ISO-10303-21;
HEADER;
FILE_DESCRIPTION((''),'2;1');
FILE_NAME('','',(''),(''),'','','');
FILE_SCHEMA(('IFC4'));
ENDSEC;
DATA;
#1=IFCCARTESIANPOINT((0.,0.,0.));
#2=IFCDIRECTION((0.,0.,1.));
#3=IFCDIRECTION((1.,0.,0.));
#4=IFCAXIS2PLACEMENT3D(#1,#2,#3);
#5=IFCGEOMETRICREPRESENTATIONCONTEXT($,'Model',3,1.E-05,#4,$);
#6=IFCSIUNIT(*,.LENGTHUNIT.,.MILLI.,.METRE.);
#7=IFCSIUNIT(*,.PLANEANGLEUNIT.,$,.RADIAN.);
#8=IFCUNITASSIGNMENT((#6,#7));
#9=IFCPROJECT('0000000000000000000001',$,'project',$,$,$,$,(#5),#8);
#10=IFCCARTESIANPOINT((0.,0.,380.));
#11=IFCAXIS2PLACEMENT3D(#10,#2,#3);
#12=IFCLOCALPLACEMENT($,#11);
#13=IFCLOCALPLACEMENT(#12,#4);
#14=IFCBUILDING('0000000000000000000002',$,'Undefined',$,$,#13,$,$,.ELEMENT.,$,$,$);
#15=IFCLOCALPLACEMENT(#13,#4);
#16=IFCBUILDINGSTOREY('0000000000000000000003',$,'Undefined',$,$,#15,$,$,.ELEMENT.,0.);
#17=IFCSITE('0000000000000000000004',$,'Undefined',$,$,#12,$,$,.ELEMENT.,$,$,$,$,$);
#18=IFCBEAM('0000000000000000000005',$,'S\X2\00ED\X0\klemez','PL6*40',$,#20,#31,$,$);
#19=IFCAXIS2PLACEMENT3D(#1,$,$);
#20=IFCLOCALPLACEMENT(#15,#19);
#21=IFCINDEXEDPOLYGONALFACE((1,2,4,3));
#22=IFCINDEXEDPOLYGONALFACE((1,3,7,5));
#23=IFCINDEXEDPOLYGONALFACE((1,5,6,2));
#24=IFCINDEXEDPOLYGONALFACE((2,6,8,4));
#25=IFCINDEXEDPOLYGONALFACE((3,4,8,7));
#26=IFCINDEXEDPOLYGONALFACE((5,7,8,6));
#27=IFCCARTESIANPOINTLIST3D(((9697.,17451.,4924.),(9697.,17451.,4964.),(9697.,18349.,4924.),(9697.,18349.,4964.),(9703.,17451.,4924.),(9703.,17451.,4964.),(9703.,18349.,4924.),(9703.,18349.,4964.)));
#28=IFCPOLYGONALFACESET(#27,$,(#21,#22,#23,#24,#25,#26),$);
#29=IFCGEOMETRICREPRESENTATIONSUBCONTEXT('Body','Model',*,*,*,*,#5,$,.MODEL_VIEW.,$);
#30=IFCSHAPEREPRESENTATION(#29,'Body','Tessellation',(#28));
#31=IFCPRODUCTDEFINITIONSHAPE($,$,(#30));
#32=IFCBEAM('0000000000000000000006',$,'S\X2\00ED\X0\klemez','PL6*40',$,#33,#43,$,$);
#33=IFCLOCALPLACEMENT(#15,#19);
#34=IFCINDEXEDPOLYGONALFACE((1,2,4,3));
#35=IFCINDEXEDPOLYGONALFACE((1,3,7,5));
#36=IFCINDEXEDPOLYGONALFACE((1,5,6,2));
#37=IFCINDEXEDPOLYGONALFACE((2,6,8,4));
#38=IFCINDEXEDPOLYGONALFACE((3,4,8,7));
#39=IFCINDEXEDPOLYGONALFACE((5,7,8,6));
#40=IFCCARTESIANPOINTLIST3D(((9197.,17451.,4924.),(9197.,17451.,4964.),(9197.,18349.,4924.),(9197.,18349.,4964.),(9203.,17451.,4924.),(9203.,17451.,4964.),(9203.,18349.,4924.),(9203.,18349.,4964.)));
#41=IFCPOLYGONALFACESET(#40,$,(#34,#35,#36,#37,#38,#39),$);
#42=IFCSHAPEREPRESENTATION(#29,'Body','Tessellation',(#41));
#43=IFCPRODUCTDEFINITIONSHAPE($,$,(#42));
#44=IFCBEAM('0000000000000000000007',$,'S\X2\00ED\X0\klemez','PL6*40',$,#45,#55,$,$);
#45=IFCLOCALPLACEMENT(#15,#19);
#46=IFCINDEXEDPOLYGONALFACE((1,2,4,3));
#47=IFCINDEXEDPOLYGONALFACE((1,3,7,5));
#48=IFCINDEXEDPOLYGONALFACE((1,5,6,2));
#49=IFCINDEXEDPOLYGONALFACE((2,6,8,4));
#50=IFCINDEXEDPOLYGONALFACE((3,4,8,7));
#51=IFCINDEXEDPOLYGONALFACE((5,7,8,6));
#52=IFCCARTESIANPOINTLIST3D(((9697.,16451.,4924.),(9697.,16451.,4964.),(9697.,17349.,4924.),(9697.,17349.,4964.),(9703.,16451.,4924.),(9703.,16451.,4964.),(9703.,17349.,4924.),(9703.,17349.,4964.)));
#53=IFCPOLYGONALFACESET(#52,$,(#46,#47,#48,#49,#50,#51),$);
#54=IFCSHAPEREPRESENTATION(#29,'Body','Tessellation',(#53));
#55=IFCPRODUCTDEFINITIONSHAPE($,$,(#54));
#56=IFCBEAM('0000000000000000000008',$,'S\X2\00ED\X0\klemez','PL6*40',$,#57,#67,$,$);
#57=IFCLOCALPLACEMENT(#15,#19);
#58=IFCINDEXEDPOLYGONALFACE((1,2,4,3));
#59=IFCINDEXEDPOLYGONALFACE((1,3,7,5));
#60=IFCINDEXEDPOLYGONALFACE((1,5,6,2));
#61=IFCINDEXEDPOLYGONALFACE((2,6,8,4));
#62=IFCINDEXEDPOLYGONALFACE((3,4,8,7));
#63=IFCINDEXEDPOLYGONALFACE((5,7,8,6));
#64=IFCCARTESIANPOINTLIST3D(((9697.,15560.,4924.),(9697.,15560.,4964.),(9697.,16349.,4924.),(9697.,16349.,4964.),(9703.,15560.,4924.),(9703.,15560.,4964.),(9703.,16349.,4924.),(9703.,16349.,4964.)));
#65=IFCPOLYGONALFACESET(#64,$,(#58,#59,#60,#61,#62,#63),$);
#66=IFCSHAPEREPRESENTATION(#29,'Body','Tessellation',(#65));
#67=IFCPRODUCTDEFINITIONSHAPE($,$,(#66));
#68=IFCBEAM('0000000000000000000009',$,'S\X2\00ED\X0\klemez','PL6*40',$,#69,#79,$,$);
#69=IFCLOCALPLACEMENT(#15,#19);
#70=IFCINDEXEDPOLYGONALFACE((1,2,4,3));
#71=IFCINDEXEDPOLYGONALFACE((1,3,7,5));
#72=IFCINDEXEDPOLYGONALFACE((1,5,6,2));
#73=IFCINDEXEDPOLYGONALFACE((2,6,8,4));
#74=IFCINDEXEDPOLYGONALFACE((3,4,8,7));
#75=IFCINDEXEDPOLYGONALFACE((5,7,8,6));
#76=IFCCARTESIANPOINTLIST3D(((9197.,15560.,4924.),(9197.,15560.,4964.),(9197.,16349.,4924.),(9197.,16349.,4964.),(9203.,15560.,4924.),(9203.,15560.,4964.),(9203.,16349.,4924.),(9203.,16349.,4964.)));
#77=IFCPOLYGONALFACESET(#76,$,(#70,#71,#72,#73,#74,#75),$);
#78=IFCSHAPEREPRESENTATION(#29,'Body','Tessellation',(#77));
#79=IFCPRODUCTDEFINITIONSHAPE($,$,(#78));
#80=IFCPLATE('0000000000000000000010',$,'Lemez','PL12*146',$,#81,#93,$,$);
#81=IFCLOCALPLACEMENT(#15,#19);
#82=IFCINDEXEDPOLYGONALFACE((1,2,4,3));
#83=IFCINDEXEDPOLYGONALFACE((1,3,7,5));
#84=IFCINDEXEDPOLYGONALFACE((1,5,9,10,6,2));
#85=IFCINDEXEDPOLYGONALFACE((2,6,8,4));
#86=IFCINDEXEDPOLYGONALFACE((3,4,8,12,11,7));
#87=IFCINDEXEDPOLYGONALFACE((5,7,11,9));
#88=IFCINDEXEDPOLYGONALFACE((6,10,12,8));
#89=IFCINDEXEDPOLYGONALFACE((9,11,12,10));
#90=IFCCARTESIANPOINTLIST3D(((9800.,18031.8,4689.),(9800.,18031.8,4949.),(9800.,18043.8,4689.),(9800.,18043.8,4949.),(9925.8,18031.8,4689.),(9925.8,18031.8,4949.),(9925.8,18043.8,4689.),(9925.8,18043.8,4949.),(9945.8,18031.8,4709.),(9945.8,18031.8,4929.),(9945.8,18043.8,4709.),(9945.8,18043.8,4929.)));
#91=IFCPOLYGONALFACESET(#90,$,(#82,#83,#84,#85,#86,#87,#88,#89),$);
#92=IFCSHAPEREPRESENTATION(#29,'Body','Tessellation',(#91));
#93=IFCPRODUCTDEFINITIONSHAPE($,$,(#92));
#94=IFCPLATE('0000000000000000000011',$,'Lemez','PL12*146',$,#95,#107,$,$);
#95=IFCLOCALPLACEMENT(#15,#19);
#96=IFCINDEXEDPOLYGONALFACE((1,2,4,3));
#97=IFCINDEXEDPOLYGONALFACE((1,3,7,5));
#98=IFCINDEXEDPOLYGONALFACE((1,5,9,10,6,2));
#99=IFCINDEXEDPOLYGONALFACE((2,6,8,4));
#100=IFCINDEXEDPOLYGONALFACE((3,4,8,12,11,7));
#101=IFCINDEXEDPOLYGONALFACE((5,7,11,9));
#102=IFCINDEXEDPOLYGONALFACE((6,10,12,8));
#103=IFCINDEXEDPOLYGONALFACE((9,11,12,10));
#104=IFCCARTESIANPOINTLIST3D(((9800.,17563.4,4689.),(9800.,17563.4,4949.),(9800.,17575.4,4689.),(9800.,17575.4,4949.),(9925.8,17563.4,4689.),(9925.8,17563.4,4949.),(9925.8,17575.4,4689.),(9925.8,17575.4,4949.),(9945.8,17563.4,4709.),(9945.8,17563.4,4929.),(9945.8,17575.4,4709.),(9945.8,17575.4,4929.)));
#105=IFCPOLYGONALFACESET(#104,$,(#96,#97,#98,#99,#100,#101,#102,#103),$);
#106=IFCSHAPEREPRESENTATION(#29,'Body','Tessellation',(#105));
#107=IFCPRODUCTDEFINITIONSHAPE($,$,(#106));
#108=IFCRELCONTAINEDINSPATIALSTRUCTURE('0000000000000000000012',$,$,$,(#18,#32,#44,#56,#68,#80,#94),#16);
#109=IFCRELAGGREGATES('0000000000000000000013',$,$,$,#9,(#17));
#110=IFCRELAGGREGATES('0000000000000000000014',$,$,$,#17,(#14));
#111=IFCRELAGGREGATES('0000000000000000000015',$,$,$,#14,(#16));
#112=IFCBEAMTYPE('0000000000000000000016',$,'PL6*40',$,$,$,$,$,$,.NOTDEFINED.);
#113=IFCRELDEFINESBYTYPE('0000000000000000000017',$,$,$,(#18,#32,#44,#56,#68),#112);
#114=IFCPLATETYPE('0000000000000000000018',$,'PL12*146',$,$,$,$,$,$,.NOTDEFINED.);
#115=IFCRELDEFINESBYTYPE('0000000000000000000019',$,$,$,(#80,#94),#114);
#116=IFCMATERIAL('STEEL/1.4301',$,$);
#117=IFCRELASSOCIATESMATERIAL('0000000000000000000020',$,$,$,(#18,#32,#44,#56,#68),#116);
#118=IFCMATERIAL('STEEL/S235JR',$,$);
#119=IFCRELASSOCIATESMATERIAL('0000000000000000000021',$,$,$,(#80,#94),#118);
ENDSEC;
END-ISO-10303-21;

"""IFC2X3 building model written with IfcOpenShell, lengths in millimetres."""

from ifc_helpers import new_model, si_unit, frame, origin_with_axes, origin_2d_with_axis, place, context, subcontext, project, spatial, polyline, rectangle, outline, extrude, material, type_object, element, save


model = new_model("IFC2X3")

# Units and contexts
model_context = context("Model", 3, precision=1e-05, world=origin_with_axes())
body_context = subcontext(model_context, "Body", "Model", "MODEL_VIEW")
ifc_project = project(units=[si_unit("LENGTHUNIT", "METRE", prefix="MILLI"), si_unit("PLANEANGLEUNIT", "RADIAN")], contexts=[model_context])

# Site, building, storey
site_placement = place(None, frame((0.0, 0.0, 380.0), z_axis=(0.0, 0.0, 1.0), x_axis=(1.0, 0.0, 0.0)))
site = spatial("IfcSite", under=ifc_project, at=site_placement, Name="Undefined", CompositionType="ELEMENT")
building_placement = place(site_placement, origin_with_axes())
building = spatial("IfcBuilding", under=site, at=building_placement, Name="Undefined", CompositionType="ELEMENT")
storey_placement = place(building_placement, origin_with_axes())
storey = spatial("IfcBuildingStorey", under=building, at=storey_placement, Name="Undefined", CompositionType="ELEMENT", Elevation=0.0)

# Shared definitions
ifc_material_1 = material(Name="STEEL/S235JR")

# Beams
ifc_material_2 = material(Name="STEEL/1.4301")
beam_type_1 = type_object("IfcBeamType", Name="PL6*40", PredefinedType="NOTDEFINED")
for number, where, z_axis, x_axis, name in (
    (1, (9700.0, 18349.0, 4944.0), (0.0, 0.0, 1.0), (0.0, -1.0, 0.0), "Síklemez"),
    (2, (9200.0, 18349.0, 4944.0), (0.0, 0.0, 1.0), (0.0, -1.0, 0.0), "Síklemez"),
    (3, (9700.0, 17349.0, 4944.0), (0.0, 0.0, 1.0), (0.0, -1.0, 0.0), "Síklemez"),
):
    element("IfcBeam", number, at=place(storey_placement, frame(where, z_axis=z_axis, x_axis=x_axis)), inside=storey, type_object=beam_type_1, material=ifc_material_2, Name=name, Description="PL6*40", context=body_context, shape_type="SweptSolid", body=[
        extrude(rectangle(XDim=6.0, YDim=40.0, at=origin_2d_with_axis()), frame((898.0, 0.0, 0.0), z_axis=(-1.0, 0.0, 0.0), x_axis=(0.0, -1.0, 0.0)), (0.0, 0.0, 1.0), 898.0),
    ])
for number, where, z_axis, x_axis, name in (
    (4, (9700.0, 16349.0, 4944.0), (0.0, 0.0, 1.0), (0.0, -1.0, 0.0), "Síklemez"),
    (5, (9200.0, 16349.0, 4944.0), (0.0, 0.0, 1.0), (0.0, -1.0, 0.0), "Síklemez"),
):
    element("IfcBeam", number, at=place(storey_placement, frame(where, z_axis=z_axis, x_axis=x_axis)), inside=storey, type_object=beam_type_1, material=ifc_material_2, Name=name, Description="PL6*40", context=body_context, shape_type="SweptSolid", body=[
        extrude(rectangle(XDim=6.0, YDim=40.0, at=origin_2d_with_axis()), frame((789.0, 0.0, 0.0), z_axis=(-1.0, 0.0, 0.0), x_axis=(0.0, -1.0, 0.0)), (0.0, 0.0, 1.0), 789.0),
    ])

# Plates
plate_type = type_object("IfcPlateType", Name="PL12*146", PredefinedType="NOTDEFINED")
for number, where, z_axis, x_axis, name in (
    (6, (9800.0, 18037.8, 4689.0), (0.0, 1.0, 0.0), (0.0, 0.0, 1.0), "Lemez"),
    (7, (9800.0, 17569.4, 4689.0), (0.0, 1.0, 0.0), (0.0, 0.0, 1.0), "Lemez"),
):
    element("IfcPlate", number, at=place(storey_placement, frame(where, z_axis=z_axis, x_axis=x_axis)), inside=storey, type_object=plate_type, material=ifc_material_1, Name=name, Description="PL12*146", context=body_context, shape_type="SweptSolid", body=[
        extrude(outline(polyline([(0.0, 0.0), (260.0, 0.0), (260.0, 125.8), (240.0, 145.8), (20.0, 145.8), (0.0, 125.8), (0.0, 0.0)])), frame((0.0, 0.0, -6.0), z_axis=(0.0, 0.0, 1.0), x_axis=(1.0, 0.0, 0.0)), (0.0, 0.0, 1.0), 12.0),
    ])

save(model, "model.ifc")
